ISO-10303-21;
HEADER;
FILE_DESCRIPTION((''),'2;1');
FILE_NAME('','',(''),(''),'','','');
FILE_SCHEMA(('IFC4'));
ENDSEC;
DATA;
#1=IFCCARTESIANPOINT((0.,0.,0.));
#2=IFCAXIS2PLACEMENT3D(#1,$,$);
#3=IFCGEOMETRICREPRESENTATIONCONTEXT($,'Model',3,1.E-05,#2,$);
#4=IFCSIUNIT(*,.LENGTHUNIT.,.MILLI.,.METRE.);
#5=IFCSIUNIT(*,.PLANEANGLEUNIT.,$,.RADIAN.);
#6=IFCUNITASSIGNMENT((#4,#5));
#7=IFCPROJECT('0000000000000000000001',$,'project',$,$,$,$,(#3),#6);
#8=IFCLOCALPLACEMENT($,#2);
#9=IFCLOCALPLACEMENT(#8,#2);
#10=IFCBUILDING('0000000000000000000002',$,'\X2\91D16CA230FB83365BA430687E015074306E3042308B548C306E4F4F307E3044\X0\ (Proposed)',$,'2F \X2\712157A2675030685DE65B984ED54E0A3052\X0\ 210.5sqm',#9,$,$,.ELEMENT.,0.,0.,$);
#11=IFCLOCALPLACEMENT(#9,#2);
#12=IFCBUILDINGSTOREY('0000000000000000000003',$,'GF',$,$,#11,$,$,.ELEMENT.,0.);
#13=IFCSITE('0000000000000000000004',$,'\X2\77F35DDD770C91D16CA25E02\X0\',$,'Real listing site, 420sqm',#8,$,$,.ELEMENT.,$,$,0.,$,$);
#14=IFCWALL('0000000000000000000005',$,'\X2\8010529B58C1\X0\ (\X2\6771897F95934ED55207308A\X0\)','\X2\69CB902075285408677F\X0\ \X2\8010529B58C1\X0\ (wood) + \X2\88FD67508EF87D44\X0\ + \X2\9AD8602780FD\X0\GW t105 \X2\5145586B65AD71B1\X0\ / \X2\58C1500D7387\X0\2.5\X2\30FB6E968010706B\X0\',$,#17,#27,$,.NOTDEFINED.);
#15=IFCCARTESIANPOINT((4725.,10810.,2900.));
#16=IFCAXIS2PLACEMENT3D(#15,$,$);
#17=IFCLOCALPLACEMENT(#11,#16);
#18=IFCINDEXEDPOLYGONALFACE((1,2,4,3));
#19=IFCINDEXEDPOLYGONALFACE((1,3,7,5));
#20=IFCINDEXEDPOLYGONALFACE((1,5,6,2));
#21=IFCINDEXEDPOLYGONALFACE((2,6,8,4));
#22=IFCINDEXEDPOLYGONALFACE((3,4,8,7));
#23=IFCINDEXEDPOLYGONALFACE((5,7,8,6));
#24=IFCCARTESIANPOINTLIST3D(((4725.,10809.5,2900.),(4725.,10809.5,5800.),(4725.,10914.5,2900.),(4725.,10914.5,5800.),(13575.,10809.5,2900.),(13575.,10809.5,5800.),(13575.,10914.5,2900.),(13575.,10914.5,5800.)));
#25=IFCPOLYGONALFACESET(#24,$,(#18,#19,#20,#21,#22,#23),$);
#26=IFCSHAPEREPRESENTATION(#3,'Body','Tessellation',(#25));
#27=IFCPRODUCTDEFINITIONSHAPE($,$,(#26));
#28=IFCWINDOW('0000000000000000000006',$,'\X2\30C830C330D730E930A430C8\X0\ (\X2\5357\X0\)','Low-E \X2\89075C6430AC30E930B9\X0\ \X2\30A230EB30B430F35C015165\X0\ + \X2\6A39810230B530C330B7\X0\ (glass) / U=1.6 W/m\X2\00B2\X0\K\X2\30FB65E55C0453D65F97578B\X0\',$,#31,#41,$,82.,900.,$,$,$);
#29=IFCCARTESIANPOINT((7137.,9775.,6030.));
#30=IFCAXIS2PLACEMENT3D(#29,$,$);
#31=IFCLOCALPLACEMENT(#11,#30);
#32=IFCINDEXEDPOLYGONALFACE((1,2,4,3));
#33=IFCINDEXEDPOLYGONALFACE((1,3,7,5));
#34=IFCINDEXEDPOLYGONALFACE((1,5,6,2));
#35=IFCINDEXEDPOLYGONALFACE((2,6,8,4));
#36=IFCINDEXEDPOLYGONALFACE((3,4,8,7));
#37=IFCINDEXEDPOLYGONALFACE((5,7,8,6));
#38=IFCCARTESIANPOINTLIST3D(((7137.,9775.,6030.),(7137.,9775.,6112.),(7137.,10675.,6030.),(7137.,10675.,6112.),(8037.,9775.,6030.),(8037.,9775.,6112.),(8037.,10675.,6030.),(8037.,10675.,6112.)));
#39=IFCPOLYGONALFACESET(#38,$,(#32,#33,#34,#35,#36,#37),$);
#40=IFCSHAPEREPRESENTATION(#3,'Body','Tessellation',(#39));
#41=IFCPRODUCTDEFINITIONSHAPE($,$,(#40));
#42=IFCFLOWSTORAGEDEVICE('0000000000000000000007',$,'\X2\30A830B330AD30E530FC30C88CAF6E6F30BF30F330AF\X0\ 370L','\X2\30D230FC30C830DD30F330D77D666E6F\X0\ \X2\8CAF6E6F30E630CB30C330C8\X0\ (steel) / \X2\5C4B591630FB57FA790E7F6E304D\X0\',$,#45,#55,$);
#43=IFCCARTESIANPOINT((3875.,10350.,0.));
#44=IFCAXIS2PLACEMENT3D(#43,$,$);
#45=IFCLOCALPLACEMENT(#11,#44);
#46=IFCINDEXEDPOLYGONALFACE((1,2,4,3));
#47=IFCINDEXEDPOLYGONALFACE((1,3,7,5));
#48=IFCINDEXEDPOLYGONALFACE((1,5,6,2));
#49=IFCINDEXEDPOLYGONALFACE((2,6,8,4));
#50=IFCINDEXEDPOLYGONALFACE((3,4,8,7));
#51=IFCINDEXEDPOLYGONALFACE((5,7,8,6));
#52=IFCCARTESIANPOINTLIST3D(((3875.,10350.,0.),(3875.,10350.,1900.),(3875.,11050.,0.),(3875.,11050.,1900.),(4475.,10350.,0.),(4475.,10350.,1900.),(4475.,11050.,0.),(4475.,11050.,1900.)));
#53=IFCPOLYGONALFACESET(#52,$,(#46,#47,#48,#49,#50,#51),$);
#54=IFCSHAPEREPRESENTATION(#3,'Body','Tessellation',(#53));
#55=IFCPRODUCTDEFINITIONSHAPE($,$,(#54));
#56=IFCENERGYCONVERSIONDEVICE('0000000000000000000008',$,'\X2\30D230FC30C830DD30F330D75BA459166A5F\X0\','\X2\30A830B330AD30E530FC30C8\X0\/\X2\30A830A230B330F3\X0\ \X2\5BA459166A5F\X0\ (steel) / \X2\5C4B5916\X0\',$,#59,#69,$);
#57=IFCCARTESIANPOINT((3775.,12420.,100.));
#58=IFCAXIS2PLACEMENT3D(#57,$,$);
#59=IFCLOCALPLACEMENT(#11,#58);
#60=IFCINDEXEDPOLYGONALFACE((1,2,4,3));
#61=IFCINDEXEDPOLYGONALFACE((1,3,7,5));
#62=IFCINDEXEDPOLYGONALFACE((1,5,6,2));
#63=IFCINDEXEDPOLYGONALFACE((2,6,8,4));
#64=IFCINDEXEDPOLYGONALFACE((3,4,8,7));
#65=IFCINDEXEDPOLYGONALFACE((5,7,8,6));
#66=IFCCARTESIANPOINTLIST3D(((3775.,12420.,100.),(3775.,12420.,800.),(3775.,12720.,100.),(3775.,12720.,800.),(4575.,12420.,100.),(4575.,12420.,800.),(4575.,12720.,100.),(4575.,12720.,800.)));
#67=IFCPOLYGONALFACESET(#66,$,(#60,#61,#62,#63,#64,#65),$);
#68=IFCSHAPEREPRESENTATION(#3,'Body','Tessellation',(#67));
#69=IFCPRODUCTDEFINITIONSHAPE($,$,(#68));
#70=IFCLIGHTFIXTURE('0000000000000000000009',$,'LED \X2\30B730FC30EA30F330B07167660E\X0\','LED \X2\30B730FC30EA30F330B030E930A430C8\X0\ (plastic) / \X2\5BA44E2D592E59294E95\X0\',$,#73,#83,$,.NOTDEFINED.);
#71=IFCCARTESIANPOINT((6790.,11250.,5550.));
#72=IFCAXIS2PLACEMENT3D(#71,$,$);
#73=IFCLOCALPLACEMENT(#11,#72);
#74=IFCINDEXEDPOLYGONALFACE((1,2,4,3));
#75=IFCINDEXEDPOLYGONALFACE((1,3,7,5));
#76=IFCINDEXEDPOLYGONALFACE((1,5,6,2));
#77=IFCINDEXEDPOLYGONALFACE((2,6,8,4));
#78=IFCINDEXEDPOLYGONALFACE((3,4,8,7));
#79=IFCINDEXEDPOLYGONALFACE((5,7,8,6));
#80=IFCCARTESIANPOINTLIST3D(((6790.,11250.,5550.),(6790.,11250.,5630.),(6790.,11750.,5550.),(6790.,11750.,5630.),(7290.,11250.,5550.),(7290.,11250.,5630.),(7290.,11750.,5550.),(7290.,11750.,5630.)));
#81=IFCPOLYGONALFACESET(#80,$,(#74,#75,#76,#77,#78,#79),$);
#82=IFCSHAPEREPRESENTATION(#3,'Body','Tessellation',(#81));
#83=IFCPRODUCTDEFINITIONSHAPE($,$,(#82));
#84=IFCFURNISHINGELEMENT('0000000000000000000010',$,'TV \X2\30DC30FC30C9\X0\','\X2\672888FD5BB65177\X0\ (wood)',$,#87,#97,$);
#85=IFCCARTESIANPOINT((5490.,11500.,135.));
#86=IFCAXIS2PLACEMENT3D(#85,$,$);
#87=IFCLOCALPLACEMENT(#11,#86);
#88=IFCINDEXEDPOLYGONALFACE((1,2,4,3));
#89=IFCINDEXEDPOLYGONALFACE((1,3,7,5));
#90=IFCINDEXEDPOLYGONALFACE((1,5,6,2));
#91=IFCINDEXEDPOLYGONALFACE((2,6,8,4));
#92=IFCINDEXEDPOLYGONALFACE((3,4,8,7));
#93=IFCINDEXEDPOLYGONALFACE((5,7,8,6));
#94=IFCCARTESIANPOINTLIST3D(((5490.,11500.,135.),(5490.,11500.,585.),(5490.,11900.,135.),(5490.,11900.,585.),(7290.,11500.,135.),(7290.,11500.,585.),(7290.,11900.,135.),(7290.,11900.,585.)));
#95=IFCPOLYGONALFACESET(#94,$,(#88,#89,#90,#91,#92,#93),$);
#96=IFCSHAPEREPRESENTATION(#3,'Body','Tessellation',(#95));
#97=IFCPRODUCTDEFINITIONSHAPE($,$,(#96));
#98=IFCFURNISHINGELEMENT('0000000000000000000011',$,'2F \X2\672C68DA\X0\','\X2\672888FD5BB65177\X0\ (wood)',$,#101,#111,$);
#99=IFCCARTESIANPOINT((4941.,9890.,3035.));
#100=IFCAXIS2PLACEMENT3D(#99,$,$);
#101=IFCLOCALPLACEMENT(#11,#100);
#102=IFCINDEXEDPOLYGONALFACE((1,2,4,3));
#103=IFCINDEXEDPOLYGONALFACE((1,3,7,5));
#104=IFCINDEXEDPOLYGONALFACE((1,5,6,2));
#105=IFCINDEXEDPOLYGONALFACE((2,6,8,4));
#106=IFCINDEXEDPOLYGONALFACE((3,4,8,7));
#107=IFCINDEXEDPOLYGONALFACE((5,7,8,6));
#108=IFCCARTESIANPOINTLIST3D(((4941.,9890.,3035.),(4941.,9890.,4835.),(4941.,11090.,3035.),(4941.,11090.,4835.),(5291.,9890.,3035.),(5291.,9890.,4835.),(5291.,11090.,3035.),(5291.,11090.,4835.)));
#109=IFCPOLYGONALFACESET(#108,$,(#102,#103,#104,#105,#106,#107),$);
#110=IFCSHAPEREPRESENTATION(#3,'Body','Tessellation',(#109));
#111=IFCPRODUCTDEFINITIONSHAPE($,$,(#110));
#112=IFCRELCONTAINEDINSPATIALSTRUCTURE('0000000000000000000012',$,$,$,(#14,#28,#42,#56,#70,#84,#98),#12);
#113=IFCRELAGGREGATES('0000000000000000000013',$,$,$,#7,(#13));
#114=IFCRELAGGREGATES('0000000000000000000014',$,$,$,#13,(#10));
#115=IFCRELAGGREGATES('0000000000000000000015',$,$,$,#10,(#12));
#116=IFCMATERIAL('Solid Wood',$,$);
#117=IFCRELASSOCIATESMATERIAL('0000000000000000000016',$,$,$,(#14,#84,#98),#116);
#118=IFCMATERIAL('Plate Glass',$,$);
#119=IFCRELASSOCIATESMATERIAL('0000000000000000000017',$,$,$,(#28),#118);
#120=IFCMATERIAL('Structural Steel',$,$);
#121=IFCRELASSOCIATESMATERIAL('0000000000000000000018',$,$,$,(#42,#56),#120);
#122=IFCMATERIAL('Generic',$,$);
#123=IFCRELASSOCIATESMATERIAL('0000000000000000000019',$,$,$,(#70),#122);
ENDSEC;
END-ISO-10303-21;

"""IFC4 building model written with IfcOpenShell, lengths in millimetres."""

from ifc_helpers import new_model, si_unit, frame, frame_2d, origin, place, context, project, spatial, rectangle, extrude, material, element, save


model = new_model("IFC4")

# Units and contexts
model_context = context("Model", 3, precision=1e-05, world=origin())
ifc_project = project(units=[si_unit("LENGTHUNIT", "METRE", prefix="MILLI"), si_unit("PLANEANGLEUNIT", "RADIAN")], contexts=[model_context])

# Site, building, storey
site_placement = place(None, origin())
site = spatial("IfcSite", under=ifc_project, at=site_placement, Name="石川県金沢市", ObjectType="Real listing site, 420sqm", CompositionType="ELEMENT", RefElevation=0.0)
building_placement = place(site_placement, origin())
building = spatial("IfcBuilding", under=site, at=building_placement, Name="金沢・茶室と縁側のある和の住まい (Proposed)", ObjectType="2F 無垢材と左官仕上げ 210.5sqm", CompositionType="ELEMENT", ElevationOfRefHeight=0.0, ElevationOfTerrain=0.0)
storey_placement = place(building_placement, origin())
storey = spatial("IfcBuildingStorey", under=building, at=storey_placement, Name="GF", CompositionType="ELEMENT", Elevation=0.0)

# Shared definitions
ifc_material_1 = material(Name="Solid Wood")

# Wall
wall_1_placement = place(storey_placement, frame((4725.0, 10810.0, 2900.0)))
element("IfcWall", 1, at=wall_1_placement, inside=storey, material=ifc_material_1, Name="耐力壁 (東西間仕切り)", Description="構造用合板 耐力壁 (wood) + 製材軸組 + 高性能GW t105 充填断熱 / 壁倍率2.5・準耐火", PredefinedType="NOTDEFINED", context=model_context, shape_type="SweptSolid", body=[
    extrude(rectangle(XDim=8850.0, YDim=105.0, at=frame_2d((4425.0, 52.0))), frame((4725.0, 10810.0, 2900.0)), (0.0, 0.0, 1.0), 2900.0),
])

# Window
ifc_material_2 = material(Name="Plate Glass")
window_placement = place(storey_placement, frame((7137.0, 9775.0, 6030.0)))
element("IfcWindow", 2, at=window_placement, inside=storey, material=ifc_material_2, Name="トップライト (南)", Description="Low-E 複層ガラス アルゴン封入 + 樹脂サッシ (glass) / U=1.6 W/m²K・日射取得型", OverallHeight=82.0, OverallWidth=900.0, context=model_context, shape_type="SweptSolid", body=[
    extrude(rectangle(XDim=900.0, YDim=900.0, at=frame_2d((450.0, 450.0))), frame((7137.0, 9775.0, 6030.0)), (0.0, 0.0, 1.0), 82.0),
])

# Flow storage device
ifc_material_3 = material(Name="Structural Steel")
flow_storage_device_placement = place(storey_placement, frame((3875.0, 10350.0, 0.0)))
element("IfcFlowStorageDevice", 3, at=flow_storage_device_placement, inside=storey, material=ifc_material_3, Name="エコキュート貯湯タンク 370L", Description="ヒートポンプ給湯 貯湯ユニット (steel) / 屋外・基礎置き", context=model_context, shape_type="SweptSolid", body=[
    extrude(rectangle(XDim=600.0, YDim=700.0, at=frame_2d((300.0, 350.0))), frame((3875.0, 10350.0, 0.0)), (0.0, 0.0, 1.0), 1900.0),
])

# Energy conversion device
energy_conversion_device_placement = place(storey_placement, frame((3775.0, 12420.0, 100.0)))
element("IfcEnergyConversionDevice", 4, at=energy_conversion_device_placement, inside=storey, material=ifc_material_3, Name="ヒートポンプ室外機", Description="エコキュート/エアコン 室外機 (steel) / 屋外", context=model_context, shape_type="SweptSolid", body=[
    extrude(rectangle(XDim=800.0, YDim=300.0, at=frame_2d((400.0, 150.0))), frame((3775.0, 12420.0, 100.0)), (0.0, 0.0, 1.0), 700.0),
])

# Light fixture
ifc_material_4 = material(Name="Generic")
light_fixture_placement = place(storey_placement, frame((6790.0, 11250.0, 5550.0)))
element("IfcLightFixture", 5, at=light_fixture_placement, inside=storey, material=ifc_material_4, Name="LED シーリング照明", Description="LED シーリングライト (plastic) / 室中央天井", PredefinedType="NOTDEFINED", context=model_context, shape_type="SweptSolid", body=[
    extrude(rectangle(XDim=500.0, YDim=500.0, at=frame_2d((250.0, 250.0))), frame((6790.0, 11250.0, 5550.0)), (0.0, 0.0, 1.0), 80.0),
])

# Furnishing elements
furnishing_1_placement = place(storey_placement, frame((5490.0, 11500.0, 135.0)))
element("IfcFurnishingElement", 6, at=furnishing_1_placement, inside=storey, material=ifc_material_1, Name="TV ボード", Description="木製家具 (wood)", context=model_context, shape_type="SweptSolid", body=[
    extrude(rectangle(XDim=1800.0, YDim=400.0, at=frame_2d((900.0, 200.0))), frame((5490.0, 11500.0, 135.0)), (0.0, 0.0, 1.0), 450.0),
])
furnishing_2_placement = place(storey_placement, frame((4941.0, 9890.0, 3035.0)))
element("IfcFurnishingElement", 7, at=furnishing_2_placement, inside=storey, material=ifc_material_1, Name="2F 本棚", Description="木製家具 (wood)", context=model_context, shape_type="SweptSolid", body=[
    extrude(rectangle(XDim=350.0, YDim=1200.0, at=frame_2d((175.0, 600.0))), frame((4941.0, 9890.0, 3035.0)), (0.0, 0.0, 1.0), 1800.0),
])

save(model, "model.ifc")
